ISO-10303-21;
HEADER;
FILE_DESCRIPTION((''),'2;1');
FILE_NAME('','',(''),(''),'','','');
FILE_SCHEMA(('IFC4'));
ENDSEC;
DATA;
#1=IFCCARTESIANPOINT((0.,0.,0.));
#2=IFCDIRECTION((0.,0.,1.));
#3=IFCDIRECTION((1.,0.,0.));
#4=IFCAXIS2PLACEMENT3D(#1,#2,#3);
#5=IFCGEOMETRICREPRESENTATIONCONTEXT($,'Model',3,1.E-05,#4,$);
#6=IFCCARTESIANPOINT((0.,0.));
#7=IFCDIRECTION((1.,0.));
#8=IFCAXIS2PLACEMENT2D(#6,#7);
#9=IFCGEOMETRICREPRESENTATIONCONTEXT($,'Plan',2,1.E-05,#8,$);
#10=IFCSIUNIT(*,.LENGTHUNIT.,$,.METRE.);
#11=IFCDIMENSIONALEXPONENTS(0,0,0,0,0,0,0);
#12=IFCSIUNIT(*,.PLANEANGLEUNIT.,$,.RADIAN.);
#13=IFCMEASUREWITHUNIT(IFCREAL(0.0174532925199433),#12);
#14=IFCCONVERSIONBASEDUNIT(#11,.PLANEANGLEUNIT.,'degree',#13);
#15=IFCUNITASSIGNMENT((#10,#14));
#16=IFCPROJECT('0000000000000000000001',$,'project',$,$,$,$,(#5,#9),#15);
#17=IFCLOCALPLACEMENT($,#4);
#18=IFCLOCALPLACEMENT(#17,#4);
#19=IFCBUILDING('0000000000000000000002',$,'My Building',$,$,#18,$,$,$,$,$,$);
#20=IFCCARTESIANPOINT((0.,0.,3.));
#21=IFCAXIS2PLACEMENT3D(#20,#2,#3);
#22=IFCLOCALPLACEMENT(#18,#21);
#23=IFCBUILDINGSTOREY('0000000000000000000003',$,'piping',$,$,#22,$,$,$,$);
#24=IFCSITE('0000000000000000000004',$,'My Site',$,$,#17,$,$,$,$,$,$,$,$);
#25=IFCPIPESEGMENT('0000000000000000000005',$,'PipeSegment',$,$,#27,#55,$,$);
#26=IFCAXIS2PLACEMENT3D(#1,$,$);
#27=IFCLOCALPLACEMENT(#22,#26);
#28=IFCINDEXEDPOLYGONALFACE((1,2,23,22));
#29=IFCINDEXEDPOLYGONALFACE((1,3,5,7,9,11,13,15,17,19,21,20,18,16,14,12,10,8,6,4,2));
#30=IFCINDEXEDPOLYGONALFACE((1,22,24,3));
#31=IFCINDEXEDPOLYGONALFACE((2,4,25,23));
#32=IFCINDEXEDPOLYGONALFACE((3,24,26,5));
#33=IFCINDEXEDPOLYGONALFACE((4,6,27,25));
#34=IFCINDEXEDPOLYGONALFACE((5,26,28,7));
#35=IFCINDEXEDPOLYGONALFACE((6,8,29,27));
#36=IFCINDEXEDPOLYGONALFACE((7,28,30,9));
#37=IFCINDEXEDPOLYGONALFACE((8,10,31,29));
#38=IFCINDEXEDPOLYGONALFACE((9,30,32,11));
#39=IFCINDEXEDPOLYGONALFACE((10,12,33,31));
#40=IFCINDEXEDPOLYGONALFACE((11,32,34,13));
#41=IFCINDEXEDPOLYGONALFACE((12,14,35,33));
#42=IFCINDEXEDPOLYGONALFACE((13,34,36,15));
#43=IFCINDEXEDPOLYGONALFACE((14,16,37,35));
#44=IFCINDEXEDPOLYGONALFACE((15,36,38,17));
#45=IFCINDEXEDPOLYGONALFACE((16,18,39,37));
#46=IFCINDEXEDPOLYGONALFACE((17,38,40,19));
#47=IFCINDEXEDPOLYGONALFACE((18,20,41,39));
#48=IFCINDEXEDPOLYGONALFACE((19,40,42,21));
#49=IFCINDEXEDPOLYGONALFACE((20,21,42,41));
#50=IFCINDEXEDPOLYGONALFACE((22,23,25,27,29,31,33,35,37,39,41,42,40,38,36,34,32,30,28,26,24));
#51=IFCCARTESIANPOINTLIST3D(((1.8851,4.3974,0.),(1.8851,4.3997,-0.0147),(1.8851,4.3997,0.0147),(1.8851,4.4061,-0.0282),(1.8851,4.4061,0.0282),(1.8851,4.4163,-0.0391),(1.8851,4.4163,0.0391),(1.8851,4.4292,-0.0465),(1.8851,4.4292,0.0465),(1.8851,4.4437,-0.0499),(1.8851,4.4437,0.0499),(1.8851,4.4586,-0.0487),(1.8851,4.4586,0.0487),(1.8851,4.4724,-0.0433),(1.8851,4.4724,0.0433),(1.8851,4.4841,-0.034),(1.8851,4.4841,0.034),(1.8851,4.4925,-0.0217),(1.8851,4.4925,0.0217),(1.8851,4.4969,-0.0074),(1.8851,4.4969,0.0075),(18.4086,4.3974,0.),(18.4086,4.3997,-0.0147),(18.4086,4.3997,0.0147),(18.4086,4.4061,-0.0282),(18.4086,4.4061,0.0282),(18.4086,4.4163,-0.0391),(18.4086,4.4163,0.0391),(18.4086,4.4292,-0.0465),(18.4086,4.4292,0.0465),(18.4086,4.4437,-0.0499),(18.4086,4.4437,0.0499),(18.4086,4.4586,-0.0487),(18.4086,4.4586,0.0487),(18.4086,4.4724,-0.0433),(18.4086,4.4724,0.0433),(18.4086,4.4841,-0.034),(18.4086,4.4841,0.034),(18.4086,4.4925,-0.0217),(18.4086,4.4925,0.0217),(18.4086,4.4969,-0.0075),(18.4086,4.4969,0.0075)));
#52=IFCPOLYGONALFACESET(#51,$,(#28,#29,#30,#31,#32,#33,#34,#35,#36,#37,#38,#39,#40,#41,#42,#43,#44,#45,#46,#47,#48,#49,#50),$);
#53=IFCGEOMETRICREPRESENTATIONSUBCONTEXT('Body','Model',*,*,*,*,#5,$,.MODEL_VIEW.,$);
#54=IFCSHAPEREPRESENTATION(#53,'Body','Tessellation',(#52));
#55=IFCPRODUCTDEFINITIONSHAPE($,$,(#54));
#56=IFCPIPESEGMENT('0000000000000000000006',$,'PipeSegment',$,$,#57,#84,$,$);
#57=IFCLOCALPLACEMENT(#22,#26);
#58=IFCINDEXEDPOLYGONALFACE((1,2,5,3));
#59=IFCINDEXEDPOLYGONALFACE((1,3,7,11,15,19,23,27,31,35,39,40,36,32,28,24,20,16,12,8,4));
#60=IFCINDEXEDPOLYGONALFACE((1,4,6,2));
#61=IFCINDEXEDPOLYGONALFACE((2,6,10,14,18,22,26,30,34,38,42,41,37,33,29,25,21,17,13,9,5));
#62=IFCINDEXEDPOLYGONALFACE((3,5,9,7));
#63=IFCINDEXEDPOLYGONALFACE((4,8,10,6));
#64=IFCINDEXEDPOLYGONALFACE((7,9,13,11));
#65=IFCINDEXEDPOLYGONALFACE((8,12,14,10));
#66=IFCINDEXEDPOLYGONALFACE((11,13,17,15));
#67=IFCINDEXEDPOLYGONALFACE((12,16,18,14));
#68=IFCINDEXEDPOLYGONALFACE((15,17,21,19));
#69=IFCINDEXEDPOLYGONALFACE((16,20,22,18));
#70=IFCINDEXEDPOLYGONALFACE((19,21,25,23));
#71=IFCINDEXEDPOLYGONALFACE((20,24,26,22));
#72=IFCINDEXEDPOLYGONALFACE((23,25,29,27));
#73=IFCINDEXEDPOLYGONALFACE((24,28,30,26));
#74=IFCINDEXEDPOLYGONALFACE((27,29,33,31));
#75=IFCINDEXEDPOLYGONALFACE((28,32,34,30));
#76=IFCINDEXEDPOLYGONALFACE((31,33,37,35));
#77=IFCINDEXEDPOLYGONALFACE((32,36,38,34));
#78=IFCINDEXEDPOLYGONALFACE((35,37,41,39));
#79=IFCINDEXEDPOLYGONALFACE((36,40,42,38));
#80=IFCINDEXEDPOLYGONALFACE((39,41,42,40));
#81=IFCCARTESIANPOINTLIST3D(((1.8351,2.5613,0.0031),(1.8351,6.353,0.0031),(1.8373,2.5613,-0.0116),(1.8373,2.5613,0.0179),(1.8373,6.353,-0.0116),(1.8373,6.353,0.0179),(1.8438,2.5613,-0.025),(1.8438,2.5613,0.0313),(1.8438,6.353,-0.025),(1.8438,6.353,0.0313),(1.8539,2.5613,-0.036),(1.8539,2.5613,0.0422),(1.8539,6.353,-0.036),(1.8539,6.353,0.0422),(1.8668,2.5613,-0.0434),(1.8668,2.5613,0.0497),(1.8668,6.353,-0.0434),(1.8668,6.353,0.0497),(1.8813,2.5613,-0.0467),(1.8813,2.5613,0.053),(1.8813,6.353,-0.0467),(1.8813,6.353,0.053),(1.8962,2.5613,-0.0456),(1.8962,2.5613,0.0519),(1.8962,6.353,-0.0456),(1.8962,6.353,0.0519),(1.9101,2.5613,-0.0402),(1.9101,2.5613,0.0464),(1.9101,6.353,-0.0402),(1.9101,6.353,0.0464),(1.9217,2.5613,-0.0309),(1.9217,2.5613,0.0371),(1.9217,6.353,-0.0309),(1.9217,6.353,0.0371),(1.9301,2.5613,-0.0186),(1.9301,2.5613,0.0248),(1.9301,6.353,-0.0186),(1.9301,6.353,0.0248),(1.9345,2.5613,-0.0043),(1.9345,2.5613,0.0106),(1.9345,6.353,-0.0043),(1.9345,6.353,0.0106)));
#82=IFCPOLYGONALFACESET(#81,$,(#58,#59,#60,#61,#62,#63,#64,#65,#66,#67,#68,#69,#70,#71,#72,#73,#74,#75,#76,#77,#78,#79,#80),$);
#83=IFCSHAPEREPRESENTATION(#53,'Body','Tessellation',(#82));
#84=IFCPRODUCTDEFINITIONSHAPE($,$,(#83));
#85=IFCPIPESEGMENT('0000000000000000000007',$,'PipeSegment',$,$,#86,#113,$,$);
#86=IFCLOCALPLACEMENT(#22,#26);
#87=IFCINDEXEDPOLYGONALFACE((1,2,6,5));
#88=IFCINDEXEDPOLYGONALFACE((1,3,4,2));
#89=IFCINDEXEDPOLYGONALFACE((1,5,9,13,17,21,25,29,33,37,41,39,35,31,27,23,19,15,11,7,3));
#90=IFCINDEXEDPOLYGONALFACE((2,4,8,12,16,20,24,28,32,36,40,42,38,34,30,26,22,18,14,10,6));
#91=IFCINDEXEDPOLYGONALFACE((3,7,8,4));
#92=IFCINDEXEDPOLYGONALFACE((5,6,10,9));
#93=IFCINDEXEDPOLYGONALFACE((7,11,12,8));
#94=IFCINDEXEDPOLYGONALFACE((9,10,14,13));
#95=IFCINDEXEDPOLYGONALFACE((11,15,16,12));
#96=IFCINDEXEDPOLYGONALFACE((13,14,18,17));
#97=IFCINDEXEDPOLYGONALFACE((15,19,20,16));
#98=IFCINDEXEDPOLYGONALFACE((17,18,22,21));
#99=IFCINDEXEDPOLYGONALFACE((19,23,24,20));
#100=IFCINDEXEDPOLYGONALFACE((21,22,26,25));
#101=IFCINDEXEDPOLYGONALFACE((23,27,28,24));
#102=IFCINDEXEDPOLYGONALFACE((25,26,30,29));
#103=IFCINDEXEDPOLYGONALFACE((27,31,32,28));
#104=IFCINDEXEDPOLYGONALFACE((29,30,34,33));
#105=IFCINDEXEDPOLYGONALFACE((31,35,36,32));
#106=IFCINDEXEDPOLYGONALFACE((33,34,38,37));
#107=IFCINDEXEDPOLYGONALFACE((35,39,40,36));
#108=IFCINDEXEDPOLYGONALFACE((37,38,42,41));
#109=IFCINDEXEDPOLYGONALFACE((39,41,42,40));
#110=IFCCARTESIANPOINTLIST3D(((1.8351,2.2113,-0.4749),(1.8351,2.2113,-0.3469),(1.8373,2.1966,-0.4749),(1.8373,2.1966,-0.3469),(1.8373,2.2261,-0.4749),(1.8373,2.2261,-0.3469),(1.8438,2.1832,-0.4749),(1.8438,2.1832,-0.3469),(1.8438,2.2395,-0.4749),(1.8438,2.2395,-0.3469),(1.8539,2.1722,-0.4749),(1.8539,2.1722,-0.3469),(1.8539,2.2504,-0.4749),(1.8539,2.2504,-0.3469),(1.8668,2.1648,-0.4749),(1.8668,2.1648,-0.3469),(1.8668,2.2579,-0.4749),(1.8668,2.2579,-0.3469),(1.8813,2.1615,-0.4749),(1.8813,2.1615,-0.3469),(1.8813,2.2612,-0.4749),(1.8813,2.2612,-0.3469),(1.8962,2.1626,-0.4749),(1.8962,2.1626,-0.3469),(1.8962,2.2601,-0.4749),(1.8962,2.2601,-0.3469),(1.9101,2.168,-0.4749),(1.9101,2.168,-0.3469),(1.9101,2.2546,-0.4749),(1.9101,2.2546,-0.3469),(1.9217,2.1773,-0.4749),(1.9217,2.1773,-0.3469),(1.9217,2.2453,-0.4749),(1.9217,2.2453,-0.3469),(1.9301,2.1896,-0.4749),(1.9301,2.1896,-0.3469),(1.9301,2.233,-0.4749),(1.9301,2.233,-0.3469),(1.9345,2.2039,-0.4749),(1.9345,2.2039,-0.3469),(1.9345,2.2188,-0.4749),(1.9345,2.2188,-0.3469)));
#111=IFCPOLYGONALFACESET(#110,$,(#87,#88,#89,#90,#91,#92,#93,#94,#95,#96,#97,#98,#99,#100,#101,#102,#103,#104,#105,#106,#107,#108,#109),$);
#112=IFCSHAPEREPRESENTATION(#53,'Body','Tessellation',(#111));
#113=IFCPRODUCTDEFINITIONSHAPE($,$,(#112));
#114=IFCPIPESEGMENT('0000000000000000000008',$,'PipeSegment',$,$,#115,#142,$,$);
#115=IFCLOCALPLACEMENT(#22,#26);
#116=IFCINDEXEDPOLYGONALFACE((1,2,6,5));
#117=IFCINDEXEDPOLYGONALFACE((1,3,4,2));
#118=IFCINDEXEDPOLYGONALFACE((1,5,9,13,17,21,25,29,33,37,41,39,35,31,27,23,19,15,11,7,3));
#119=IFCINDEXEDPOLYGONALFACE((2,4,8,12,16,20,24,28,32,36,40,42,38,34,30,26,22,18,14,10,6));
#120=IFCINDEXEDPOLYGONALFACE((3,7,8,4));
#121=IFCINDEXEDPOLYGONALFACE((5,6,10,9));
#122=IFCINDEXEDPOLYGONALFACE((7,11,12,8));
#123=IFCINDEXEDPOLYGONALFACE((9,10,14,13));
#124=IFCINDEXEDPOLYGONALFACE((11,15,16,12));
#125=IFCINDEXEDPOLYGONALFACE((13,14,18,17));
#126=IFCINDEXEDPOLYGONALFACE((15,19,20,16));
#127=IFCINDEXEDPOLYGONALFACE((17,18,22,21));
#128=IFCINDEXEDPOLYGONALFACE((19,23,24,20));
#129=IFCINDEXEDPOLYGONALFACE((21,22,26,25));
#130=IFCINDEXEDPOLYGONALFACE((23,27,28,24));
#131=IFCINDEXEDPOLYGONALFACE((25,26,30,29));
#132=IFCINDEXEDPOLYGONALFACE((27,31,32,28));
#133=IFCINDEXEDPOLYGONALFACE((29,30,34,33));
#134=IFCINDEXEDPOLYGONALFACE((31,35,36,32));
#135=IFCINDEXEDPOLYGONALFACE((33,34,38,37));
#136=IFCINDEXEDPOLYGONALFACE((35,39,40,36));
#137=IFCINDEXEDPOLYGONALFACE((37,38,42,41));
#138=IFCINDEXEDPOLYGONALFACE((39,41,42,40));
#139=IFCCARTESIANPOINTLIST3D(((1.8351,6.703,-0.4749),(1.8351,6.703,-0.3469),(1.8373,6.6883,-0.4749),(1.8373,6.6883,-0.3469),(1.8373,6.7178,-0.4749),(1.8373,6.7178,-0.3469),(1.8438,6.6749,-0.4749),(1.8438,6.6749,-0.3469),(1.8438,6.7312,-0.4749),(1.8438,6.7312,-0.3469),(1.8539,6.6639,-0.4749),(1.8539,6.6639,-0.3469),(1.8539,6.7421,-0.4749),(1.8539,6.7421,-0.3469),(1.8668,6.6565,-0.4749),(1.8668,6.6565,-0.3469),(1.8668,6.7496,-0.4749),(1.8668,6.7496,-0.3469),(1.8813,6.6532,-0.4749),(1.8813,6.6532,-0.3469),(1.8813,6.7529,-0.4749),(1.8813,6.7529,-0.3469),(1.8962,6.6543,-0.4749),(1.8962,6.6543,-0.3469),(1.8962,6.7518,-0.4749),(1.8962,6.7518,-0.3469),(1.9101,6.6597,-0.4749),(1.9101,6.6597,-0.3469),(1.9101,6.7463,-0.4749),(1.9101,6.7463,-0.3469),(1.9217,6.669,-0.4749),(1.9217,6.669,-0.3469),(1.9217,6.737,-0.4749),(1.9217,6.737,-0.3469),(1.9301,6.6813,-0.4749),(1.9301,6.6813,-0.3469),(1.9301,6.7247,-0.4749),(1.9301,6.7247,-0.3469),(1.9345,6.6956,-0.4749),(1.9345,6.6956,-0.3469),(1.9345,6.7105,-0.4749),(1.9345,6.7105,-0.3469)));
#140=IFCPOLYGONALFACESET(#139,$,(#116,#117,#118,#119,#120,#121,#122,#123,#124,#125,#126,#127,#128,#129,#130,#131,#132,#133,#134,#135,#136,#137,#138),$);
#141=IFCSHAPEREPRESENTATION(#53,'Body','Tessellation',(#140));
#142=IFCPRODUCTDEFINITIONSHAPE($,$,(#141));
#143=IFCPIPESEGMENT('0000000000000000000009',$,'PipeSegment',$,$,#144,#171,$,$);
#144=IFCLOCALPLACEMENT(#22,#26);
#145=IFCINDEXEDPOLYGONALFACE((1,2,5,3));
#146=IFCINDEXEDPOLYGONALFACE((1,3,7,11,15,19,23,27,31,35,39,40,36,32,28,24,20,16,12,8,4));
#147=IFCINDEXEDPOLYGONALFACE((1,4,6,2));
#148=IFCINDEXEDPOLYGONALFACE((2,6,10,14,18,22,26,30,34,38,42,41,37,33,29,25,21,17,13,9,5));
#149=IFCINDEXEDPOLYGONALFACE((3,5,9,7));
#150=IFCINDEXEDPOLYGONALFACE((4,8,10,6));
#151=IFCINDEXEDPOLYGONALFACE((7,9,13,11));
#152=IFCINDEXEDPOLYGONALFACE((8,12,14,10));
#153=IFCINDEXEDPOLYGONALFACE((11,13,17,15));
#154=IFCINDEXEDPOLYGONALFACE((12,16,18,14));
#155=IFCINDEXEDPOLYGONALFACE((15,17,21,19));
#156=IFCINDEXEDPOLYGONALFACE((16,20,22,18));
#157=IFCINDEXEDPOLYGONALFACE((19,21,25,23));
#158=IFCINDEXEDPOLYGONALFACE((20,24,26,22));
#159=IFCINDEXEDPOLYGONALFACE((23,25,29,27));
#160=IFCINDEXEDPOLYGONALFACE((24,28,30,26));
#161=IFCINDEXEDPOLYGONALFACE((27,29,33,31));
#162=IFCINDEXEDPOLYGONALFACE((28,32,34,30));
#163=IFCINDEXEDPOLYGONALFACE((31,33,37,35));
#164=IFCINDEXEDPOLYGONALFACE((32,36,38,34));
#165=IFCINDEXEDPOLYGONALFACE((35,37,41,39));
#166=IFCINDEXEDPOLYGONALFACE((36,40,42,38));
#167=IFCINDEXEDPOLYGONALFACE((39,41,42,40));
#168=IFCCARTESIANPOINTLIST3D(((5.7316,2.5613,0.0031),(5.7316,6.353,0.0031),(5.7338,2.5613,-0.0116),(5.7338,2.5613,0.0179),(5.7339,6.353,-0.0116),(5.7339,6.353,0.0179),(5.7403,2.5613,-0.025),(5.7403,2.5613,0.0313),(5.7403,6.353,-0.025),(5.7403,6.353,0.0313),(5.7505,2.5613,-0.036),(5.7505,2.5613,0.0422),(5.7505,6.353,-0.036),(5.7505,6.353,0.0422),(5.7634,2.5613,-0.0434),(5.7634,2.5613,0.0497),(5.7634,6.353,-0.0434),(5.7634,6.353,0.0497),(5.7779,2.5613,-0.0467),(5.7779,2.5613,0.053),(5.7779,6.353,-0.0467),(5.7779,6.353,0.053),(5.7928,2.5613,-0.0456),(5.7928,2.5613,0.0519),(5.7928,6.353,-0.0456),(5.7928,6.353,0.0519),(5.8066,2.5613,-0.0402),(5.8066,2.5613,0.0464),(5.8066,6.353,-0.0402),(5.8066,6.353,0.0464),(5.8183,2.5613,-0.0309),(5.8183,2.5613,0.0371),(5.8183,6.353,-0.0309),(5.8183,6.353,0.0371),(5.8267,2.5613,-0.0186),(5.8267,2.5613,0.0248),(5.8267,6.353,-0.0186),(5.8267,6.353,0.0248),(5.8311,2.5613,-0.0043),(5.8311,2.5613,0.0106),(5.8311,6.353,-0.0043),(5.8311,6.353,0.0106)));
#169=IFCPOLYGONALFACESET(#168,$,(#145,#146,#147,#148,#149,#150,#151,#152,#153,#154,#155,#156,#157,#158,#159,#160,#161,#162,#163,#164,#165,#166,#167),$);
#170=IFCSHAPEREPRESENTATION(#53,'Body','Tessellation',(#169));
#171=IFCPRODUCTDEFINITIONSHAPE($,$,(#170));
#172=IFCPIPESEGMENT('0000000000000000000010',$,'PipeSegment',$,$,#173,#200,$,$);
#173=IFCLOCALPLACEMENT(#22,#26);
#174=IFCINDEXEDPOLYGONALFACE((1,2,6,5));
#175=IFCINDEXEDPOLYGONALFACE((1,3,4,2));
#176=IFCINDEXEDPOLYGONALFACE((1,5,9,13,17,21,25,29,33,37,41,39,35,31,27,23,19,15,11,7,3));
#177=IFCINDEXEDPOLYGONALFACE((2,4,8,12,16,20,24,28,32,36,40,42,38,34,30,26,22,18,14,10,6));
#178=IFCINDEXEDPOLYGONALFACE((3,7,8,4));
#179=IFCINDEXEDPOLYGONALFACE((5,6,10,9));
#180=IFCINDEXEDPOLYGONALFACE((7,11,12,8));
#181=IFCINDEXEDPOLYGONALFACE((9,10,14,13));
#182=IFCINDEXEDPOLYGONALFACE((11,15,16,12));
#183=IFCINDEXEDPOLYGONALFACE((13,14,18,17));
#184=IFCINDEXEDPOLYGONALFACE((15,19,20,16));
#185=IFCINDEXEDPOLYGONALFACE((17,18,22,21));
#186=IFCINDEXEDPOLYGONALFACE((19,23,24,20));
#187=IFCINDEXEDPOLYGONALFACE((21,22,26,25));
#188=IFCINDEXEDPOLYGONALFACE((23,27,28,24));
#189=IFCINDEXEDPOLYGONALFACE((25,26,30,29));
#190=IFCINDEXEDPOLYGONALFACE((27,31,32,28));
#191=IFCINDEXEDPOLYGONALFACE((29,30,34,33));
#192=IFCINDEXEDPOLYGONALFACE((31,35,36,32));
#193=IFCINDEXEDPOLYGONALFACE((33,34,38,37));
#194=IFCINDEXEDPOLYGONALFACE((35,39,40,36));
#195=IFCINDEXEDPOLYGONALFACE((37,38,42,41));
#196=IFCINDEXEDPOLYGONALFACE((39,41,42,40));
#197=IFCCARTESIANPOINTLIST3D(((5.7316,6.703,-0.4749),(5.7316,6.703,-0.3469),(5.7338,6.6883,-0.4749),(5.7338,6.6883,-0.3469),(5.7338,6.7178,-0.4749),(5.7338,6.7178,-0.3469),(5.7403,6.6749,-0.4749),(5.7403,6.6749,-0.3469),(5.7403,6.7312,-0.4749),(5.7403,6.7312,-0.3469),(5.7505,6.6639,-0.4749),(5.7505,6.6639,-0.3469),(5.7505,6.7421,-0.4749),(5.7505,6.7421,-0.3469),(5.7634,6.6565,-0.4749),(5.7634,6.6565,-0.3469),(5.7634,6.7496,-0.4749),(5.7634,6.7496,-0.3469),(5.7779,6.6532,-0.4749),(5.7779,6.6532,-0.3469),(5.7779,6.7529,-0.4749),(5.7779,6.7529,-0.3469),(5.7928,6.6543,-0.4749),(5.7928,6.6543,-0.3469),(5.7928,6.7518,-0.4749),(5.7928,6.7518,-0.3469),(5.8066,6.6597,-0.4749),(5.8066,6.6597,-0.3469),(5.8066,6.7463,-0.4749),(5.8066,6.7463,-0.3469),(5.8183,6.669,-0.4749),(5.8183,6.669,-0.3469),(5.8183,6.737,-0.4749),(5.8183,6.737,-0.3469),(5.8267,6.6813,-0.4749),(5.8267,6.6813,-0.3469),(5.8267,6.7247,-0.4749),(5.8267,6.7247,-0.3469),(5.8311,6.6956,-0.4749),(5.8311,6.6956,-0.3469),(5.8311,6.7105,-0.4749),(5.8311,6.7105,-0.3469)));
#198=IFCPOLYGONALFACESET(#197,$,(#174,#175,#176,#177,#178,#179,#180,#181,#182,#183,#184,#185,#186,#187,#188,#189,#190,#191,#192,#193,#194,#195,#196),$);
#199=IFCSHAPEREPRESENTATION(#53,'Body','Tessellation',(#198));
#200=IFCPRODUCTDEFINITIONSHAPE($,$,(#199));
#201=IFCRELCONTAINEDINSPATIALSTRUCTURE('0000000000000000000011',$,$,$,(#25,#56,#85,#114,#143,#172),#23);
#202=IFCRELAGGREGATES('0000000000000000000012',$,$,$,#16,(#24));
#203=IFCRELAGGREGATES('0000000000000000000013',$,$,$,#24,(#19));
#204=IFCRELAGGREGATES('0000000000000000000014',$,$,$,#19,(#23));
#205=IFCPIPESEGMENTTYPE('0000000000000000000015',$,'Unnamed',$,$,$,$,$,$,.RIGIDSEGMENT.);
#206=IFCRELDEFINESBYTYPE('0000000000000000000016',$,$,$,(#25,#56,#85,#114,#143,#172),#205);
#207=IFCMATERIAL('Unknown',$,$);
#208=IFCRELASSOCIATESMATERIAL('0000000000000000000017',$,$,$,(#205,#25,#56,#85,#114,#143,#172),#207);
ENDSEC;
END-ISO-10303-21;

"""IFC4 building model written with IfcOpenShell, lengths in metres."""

from ifc_helpers import new_model, entity, si_unit, converted_unit, frame, origin_with_axes, origin_2d_with_axis, place, context, subcontext, project, spatial, circle, extrude, material, material_profile, profile_set, profile_usage, type_object, element, save


model = new_model("IFC4")

# Units and contexts
model_context = context("Model", 3, precision=1e-05, world=origin_with_axes())
plan_context = context("Plan", 2, precision=1e-05, world=origin_2d_with_axis())
body_context = subcontext(model_context, "Body", "Model", "MODEL_VIEW")
ifc_project = project(units=[si_unit("LENGTHUNIT", "METRE"), converted_unit("PLANEANGLEUNIT", "degree", entity("IfcReal", 0.0174532925199433), si_unit("PLANEANGLEUNIT", "RADIAN"), dimensions=[0, 0, 0, 0, 0, 0, 0])], contexts=[model_context, plan_context])

# Site, building, storey
site_placement = place(None, origin_with_axes())
site = spatial("IfcSite", under=ifc_project, at=site_placement, Name="My Site")
building_placement = place(site_placement, origin_with_axes())
building = spatial("IfcBuilding", under=site, at=building_placement, Name="My Building")
storey_placement = place(building_placement, frame((0.0, 0.0, 3.0), z_axis=(0.0, 0.0, 1.0), x_axis=(1.0, 0.0, 0.0)))
storey = spatial("IfcBuildingStorey", under=building, at=storey_placement, Name="piping")

# Pipe segments
ifc_material = material(Name="Unknown")
ifc_material_profile = material_profile(ifc_material, circle(Radius=0.05))
ifc_profile_set = profile_set([ifc_material_profile])
ifc_profile_usage_1 = profile_usage(ifc_profile_set, cardinal=5)
pipe_segment_type = type_object("IfcPipeSegmentType", Name="Unnamed", PredefinedType="RIGIDSEGMENT", material=ifc_profile_set)
pipe_segment_1_placement = place(storey_placement, frame((18.4086, 4.4474, 0.0), z_axis=(-1.0, 0.0, 0.0), x_axis=(0.0, -1.0, 0.0)))
element("IfcPipeSegment", 1, at=pipe_segment_1_placement, inside=storey, type_object=pipe_segment_type, material=ifc_profile_usage_1, Name="PipeSegment", context=body_context, shape_type="SweptSolid", body=[
    extrude(circle(Radius=0.05), origin_with_axes(), (0.0, 0.0, 1.0), 16.5235),
])
ifc_profile_usage_2 = profile_usage(ifc_profile_set, cardinal=5)
pipe_segment_2_placement = place(storey_placement, frame((1.8851, 2.5613, 0.0031), z_axis=(0.0, 1.0, 0.0), x_axis=(-1.0, 0.0, 0.0)))
element("IfcPipeSegment", 2, at=pipe_segment_2_placement, inside=storey, type_object=pipe_segment_type, material=ifc_profile_usage_2, Name="PipeSegment", context=body_context, shape_type="SweptSolid", body=[
    extrude(circle(Radius=0.05), origin_with_axes(), (0.0, 0.0, 1.0), 3.7917),
])
ifc_profile_usage_3 = profile_usage(ifc_profile_set, cardinal=5)
pipe_segment_3_placement = place(storey_placement, frame((1.8851, 2.2113, -0.3469), z_axis=(0.0, 0.0, -1.0), x_axis=(-1.0, 0.0, 0.0)))
element("IfcPipeSegment", 3, at=pipe_segment_3_placement, inside=storey, type_object=pipe_segment_type, material=ifc_profile_usage_3, Name="PipeSegment", context=body_context, shape_type="SweptSolid", body=[
    extrude(circle(Radius=0.05), origin_with_axes(), (0.0, 0.0, 1.0), 0.128),
])
ifc_profile_usage_4 = profile_usage(ifc_profile_set, cardinal=5)
pipe_segment_4_placement = place(storey_placement, frame((1.8851, 6.703, -0.3469), z_axis=(0.0, 0.0, -1.0), x_axis=(-1.0, 0.0, 0.0)))
element("IfcPipeSegment", 4, at=pipe_segment_4_placement, inside=storey, type_object=pipe_segment_type, material=ifc_profile_usage_4, Name="PipeSegment", context=body_context, shape_type="SweptSolid", body=[
    extrude(circle(Radius=0.05), origin_with_axes(), (0.0, 0.0, 1.0), 0.128),
])
ifc_profile_usage_5 = profile_usage(ifc_profile_set, cardinal=5)
pipe_segment_5_placement = place(storey_placement, frame((5.7816, 2.5613, 0.0031), z_axis=(0.0, 1.0, 0.0), x_axis=(-1.0, 0.0, 0.0)))
element("IfcPipeSegment", 5, at=pipe_segment_5_placement, inside=storey, type_object=pipe_segment_type, material=ifc_profile_usage_5, Name="PipeSegment", context=body_context, shape_type="SweptSolid", body=[
    extrude(circle(Radius=0.05), origin_with_axes(), (0.0, 0.0, 1.0), 3.7917),
])
ifc_profile_usage_6 = profile_usage(ifc_profile_set, cardinal=5)
pipe_segment_6_placement = place(storey_placement, frame((5.7816, 6.703, -0.3469), z_axis=(0.0, 0.0, -1.0), x_axis=(-1.0, 0.0, 0.0)))
element("IfcPipeSegment", 6, at=pipe_segment_6_placement, inside=storey, type_object=pipe_segment_type, material=ifc_profile_usage_6, Name="PipeSegment", context=body_context, shape_type="SweptSolid", body=[
    extrude(circle(Radius=0.05), origin_with_axes(), (0.0, 0.0, 1.0), 0.128),
])

save(model, "model.ifc")
